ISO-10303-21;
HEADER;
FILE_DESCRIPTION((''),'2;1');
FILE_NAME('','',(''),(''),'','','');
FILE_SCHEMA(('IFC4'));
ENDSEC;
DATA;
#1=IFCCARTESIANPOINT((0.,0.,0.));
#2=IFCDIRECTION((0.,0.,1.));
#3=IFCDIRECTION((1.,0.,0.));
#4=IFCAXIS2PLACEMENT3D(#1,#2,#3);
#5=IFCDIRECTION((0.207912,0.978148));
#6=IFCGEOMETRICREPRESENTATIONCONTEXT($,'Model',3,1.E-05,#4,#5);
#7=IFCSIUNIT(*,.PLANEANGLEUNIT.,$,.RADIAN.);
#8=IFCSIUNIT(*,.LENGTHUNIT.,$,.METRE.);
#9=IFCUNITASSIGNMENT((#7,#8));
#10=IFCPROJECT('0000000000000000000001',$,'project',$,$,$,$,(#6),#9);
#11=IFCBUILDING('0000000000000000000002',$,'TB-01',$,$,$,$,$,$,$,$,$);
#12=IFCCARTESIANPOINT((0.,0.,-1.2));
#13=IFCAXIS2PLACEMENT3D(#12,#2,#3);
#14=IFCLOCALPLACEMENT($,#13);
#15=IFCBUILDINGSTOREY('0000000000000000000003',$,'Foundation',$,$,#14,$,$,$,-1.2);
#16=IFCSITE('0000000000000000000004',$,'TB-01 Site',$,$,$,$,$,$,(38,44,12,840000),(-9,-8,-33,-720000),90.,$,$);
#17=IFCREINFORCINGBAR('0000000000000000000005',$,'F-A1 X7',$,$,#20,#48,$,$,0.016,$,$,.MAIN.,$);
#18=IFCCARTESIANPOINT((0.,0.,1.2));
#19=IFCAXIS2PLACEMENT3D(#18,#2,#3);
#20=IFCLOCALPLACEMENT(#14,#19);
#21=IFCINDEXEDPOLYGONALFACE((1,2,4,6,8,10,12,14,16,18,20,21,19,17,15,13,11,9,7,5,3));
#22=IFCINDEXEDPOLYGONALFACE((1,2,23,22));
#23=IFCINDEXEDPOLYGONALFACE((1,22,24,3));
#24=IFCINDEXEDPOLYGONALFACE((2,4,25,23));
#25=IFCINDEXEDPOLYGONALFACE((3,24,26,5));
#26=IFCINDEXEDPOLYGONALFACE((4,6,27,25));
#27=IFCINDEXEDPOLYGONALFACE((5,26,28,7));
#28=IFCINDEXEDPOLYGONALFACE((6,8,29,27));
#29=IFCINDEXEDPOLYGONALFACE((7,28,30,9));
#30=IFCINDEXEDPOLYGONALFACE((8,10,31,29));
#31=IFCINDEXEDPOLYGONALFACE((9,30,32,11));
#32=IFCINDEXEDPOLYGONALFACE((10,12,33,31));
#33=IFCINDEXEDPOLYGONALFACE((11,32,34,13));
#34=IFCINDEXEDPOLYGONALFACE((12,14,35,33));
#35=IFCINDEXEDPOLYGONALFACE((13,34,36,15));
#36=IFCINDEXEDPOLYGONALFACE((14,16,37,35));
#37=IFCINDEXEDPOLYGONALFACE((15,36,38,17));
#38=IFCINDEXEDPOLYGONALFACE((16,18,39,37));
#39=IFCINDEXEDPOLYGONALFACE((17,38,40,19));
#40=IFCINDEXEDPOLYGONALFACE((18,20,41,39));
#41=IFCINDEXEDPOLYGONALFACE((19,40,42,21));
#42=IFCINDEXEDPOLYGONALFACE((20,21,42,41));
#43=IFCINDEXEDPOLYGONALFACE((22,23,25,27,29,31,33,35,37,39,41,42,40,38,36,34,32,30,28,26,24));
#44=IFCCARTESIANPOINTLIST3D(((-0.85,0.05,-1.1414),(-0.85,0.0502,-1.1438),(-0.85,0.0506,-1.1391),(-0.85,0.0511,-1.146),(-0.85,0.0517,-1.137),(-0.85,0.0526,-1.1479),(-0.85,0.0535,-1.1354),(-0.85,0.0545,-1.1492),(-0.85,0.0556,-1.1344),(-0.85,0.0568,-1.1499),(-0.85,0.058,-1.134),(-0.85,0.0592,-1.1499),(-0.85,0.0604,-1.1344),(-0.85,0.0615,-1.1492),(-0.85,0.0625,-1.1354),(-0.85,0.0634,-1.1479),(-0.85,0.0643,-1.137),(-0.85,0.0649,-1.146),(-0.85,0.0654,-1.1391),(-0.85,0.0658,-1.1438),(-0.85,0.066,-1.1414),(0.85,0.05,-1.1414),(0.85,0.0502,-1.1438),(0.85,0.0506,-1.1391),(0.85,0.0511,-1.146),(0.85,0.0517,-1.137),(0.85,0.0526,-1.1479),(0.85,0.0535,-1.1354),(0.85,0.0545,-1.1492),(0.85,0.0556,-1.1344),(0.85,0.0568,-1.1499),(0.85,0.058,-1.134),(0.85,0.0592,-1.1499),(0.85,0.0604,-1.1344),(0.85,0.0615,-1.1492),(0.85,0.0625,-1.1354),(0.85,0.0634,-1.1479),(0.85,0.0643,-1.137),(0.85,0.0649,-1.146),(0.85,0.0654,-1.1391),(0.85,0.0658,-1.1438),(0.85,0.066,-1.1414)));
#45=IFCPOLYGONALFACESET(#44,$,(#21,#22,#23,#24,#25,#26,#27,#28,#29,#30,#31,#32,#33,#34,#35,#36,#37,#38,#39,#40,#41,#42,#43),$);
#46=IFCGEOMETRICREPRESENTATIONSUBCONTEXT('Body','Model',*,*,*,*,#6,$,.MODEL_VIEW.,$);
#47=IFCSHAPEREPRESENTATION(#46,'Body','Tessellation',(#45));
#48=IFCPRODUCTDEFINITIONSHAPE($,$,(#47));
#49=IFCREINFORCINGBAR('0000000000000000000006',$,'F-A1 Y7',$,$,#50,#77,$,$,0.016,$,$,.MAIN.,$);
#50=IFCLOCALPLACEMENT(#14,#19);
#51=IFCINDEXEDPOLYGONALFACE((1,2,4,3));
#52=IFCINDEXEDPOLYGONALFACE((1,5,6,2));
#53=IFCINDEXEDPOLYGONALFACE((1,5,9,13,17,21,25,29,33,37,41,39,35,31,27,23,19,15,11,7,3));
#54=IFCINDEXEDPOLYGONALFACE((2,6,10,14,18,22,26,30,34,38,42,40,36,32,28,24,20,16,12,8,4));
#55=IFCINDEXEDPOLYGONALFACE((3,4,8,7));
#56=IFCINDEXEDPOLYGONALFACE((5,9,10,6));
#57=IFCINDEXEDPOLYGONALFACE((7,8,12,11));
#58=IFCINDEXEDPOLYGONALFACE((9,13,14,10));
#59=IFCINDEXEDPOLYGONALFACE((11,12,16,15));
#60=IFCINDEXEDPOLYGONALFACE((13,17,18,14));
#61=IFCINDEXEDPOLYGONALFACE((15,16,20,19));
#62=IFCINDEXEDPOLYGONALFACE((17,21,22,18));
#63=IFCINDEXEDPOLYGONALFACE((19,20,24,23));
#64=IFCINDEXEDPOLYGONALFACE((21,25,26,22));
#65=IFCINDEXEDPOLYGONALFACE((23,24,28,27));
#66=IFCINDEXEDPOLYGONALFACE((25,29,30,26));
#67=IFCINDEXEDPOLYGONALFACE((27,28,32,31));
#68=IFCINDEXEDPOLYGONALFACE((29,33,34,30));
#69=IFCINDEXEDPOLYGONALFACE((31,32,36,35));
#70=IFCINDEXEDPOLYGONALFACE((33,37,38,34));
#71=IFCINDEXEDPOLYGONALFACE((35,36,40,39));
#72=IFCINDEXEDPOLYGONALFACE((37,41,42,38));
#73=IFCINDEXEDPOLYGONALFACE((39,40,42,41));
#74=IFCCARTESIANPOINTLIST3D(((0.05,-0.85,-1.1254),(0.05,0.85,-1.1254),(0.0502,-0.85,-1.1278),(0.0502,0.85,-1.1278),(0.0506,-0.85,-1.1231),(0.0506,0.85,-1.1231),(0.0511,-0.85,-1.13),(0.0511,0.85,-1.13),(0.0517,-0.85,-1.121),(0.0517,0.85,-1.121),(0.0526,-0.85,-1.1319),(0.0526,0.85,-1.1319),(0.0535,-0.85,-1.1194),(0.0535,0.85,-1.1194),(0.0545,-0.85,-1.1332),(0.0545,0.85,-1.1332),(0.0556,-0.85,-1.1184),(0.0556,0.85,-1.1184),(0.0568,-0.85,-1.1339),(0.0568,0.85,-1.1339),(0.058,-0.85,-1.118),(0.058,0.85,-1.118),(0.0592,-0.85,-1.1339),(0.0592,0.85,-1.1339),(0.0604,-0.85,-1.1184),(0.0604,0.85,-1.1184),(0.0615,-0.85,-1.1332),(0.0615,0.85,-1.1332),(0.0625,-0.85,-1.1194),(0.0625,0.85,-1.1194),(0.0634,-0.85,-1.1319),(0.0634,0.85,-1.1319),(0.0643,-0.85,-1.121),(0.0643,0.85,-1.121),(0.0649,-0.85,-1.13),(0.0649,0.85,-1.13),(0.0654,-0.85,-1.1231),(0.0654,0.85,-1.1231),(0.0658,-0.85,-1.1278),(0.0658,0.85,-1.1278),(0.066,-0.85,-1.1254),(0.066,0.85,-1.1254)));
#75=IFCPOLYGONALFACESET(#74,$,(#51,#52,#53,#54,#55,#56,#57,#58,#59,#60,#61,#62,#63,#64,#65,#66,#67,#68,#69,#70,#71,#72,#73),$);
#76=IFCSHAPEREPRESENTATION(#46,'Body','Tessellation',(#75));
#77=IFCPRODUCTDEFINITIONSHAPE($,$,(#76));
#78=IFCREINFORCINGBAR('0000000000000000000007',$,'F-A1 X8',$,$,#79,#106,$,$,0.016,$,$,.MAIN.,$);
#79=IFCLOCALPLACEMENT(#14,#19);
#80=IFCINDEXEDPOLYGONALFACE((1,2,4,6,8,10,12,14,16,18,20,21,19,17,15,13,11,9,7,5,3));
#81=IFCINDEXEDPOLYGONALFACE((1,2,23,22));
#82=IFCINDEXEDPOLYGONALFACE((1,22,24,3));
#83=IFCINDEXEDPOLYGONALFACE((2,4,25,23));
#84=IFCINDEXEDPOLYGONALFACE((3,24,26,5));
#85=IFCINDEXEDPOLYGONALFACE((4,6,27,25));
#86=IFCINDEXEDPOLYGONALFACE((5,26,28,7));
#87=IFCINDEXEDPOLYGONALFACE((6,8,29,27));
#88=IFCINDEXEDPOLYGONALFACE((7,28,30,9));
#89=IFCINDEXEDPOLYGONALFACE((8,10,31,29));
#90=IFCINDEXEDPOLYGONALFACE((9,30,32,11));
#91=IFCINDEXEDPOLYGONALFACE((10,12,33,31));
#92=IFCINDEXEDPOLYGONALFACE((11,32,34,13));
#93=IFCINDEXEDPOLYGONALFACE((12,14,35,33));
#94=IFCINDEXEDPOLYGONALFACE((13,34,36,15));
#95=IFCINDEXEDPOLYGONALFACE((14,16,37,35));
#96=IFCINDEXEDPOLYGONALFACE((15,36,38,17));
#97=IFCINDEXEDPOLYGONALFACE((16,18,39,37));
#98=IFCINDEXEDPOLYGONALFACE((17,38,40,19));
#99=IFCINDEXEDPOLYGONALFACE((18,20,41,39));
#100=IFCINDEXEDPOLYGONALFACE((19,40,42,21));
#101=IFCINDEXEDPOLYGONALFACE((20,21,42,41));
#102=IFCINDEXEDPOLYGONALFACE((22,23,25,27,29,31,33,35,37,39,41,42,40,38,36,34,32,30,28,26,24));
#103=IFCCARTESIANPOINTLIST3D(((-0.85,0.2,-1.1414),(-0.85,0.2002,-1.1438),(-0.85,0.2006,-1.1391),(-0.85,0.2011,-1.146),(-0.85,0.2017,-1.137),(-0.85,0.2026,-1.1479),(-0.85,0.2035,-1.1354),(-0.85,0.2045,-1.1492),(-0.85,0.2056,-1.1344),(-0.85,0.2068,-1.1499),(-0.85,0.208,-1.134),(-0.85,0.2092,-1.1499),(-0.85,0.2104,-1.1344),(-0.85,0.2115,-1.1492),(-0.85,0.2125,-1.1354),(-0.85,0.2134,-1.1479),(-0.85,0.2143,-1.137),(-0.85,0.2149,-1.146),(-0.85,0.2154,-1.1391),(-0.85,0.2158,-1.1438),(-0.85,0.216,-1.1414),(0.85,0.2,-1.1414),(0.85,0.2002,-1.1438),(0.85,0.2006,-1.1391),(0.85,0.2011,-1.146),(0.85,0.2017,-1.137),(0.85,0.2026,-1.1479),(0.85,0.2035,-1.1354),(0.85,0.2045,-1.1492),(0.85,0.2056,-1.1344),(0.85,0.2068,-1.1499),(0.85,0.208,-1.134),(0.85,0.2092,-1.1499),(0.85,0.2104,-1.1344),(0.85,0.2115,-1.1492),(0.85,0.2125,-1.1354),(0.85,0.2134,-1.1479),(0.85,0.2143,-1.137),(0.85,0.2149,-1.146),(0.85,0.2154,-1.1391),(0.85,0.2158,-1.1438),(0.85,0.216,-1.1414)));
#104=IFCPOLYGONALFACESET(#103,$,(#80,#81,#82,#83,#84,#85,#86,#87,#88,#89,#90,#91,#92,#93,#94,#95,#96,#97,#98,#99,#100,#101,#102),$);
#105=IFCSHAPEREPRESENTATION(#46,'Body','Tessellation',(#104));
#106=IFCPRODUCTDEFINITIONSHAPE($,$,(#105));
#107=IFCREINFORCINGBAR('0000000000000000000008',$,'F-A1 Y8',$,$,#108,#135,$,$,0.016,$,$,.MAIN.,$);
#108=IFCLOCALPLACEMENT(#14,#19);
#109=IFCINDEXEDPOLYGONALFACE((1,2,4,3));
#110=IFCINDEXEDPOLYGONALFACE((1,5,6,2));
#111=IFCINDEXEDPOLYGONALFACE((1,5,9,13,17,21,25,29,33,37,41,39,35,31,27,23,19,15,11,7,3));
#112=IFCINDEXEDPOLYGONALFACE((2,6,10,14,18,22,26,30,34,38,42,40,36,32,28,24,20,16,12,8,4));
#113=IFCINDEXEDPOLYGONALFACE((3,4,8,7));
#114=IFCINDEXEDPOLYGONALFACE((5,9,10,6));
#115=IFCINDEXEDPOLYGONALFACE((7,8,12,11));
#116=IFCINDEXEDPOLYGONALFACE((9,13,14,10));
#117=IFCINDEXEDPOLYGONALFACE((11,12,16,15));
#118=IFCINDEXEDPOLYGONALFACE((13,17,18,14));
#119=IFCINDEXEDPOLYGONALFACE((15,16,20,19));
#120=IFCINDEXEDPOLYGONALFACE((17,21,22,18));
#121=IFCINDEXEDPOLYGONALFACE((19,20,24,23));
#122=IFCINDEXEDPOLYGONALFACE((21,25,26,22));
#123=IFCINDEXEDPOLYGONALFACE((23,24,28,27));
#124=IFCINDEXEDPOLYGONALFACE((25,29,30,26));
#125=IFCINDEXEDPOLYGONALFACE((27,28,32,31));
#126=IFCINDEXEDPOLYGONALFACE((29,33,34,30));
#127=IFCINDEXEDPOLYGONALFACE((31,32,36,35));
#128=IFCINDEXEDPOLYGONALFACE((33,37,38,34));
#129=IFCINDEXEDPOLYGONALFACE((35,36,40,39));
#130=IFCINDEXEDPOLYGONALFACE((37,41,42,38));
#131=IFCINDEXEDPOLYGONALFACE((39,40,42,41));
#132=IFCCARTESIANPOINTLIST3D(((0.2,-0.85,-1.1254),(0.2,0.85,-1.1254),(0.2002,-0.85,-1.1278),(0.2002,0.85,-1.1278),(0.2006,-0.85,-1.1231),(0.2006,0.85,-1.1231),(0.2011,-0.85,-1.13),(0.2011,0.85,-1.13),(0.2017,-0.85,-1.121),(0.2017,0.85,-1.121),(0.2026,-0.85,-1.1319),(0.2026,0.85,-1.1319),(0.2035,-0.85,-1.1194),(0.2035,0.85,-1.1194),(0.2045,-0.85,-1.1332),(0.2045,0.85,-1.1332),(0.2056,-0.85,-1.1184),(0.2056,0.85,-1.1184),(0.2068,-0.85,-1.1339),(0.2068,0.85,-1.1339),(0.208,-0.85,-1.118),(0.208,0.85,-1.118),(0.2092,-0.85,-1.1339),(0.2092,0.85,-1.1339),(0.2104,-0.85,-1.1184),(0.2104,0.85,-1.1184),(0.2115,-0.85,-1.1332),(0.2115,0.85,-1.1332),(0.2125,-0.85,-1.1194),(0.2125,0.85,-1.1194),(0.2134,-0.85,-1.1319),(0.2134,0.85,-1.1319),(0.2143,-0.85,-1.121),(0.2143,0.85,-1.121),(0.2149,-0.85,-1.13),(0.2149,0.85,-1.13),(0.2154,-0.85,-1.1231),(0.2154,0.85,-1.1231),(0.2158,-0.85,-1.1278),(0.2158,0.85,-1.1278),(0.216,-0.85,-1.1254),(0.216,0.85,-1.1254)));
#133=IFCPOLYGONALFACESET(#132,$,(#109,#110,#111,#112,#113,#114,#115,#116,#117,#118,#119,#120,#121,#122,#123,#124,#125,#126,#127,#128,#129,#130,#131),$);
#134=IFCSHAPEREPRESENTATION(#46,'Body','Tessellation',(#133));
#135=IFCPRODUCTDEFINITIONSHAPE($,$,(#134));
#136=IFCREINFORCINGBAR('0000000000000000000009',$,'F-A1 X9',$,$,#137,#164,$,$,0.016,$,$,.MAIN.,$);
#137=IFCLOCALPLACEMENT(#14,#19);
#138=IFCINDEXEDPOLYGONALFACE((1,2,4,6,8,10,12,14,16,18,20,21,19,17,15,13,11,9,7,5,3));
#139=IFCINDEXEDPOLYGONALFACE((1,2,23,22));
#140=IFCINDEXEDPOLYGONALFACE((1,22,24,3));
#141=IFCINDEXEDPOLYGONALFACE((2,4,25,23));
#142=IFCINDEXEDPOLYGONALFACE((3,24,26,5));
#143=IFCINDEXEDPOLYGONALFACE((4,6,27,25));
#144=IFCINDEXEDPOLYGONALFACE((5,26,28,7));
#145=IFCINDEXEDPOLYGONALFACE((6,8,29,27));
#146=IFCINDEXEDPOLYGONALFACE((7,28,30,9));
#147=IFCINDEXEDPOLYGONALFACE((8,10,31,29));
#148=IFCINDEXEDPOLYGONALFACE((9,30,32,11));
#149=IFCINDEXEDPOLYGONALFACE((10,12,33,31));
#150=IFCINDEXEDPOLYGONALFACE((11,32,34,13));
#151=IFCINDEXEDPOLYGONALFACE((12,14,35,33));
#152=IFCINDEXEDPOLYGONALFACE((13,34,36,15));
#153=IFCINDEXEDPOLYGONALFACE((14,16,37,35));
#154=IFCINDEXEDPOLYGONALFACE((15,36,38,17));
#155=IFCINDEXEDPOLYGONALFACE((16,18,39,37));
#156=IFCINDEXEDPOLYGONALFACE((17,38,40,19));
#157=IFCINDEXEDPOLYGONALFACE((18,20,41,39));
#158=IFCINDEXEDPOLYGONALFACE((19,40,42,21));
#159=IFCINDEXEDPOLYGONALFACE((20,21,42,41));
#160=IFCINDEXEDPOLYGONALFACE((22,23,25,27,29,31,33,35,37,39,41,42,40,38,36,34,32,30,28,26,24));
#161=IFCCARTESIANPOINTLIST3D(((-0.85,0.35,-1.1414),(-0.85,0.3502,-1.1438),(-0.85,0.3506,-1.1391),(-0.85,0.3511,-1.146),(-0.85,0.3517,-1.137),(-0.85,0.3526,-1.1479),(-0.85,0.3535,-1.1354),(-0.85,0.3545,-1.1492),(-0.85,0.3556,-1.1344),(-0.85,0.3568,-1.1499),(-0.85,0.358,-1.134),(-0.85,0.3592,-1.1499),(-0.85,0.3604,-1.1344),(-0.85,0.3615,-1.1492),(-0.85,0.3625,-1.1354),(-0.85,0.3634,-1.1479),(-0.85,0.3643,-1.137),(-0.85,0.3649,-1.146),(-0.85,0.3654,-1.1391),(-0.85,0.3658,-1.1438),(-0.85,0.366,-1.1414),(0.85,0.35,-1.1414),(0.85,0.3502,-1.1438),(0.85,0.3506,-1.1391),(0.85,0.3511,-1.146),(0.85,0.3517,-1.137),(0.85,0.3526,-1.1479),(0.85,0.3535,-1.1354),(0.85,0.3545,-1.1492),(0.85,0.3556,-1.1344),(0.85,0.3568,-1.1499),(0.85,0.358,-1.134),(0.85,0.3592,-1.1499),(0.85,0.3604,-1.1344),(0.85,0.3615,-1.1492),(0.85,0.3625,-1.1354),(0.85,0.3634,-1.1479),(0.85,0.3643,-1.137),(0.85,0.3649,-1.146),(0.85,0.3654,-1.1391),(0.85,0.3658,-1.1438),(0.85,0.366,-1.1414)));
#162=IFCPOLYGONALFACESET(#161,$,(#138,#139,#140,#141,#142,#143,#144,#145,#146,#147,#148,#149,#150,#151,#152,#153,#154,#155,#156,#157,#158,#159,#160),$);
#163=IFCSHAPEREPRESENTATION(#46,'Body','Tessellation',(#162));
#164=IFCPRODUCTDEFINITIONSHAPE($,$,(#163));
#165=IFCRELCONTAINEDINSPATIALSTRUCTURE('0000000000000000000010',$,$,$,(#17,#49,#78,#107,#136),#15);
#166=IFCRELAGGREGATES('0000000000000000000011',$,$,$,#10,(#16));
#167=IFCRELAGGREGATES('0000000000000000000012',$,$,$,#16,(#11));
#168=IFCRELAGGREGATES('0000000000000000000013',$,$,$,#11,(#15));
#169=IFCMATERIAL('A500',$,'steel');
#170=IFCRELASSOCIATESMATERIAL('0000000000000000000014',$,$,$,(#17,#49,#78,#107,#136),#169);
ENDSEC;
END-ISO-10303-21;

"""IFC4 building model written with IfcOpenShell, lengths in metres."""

from ifc_helpers import new_model, entity, si_unit, direction, frame, origin_with_axes, place, context, subcontext, project, spatial, material, element, save


model = new_model("IFC4")

# Units and contexts
model_context = context("Model", 3, precision=1e-05, world=origin_with_axes(), true_north=direction((0.207912, 0.978148)))
body_context = subcontext(model_context, "Body", "Model", "MODEL_VIEW")
ifc_project = project(units=[si_unit("PLANEANGLEUNIT", "RADIAN"), si_unit("LENGTHUNIT", "METRE")], contexts=[model_context])

# Site, building, storey
site = spatial("IfcSite", under=ifc_project, Name="TB-01 Site", RefLatitude=(38, 44, 12, 840000), RefLongitude=(-9, -8, -33, -720000), RefElevation=90.0)
building = spatial("IfcBuilding", under=site, Name="TB-01")
storey_placement = place(None, frame((0.0, 0.0, -1.2), z_axis=(0.0, 0.0, 1.0), x_axis=(1.0, 0.0, 0.0)))
storey = spatial("IfcBuildingStorey", under=building, at=storey_placement, Name="Foundation", Elevation=-1.2)

# Reinforcing bars
ifc_material_1 = material(Name="A500", Category="steel")
reinforcing_bar_1_placement = place(storey_placement, frame((0.0, 0.0, 1.2), z_axis=(0.0, 0.0, 1.0), x_axis=(1.0, 0.0, 0.0)))
element("IfcReinforcingBar", 1, at=reinforcing_bar_1_placement, inside=storey, material=ifc_material_1, Name="F-A1 X7", NominalDiameter=0.016, PredefinedType="MAIN", context=body_context, shape_type="AdvancedSweptSolid", body=[
    entity("IfcSweptDiskSolid", entity("IfcPolyline", [entity("IfcCartesianPoint", [-0.85, 0.058, -1.142]), entity("IfcCartesianPoint", [0.85, 0.058, -1.142])]), 0.008),
])
reinforcing_bar_2_placement = place(storey_placement, frame((0.0, 0.0, 1.2), z_axis=(0.0, 0.0, 1.0), x_axis=(1.0, 0.0, 0.0)))
element("IfcReinforcingBar", 2, at=reinforcing_bar_2_placement, inside=storey, material=ifc_material_1, Name="F-A1 Y7", NominalDiameter=0.016, PredefinedType="MAIN", context=body_context, shape_type="AdvancedSweptSolid", body=[
    entity("IfcSweptDiskSolid", entity("IfcPolyline", [entity("IfcCartesianPoint", [0.058, -0.85, -1.126]), entity("IfcCartesianPoint", [0.058, 0.85, -1.126])]), 0.008),
])
reinforcing_bar_3_placement = place(storey_placement, frame((0.0, 0.0, 1.2), z_axis=(0.0, 0.0, 1.0), x_axis=(1.0, 0.0, 0.0)))
element("IfcReinforcingBar", 3, at=reinforcing_bar_3_placement, inside=storey, material=ifc_material_1, Name="F-A1 X8", NominalDiameter=0.016, PredefinedType="MAIN", context=body_context, shape_type="AdvancedSweptSolid", body=[
    entity("IfcSweptDiskSolid", entity("IfcPolyline", [entity("IfcCartesianPoint", [-0.85, 0.208, -1.142]), entity("IfcCartesianPoint", [0.85, 0.208, -1.142])]), 0.008),
])
reinforcing_bar_4_placement = place(storey_placement, frame((0.0, 0.0, 1.2), z_axis=(0.0, 0.0, 1.0), x_axis=(1.0, 0.0, 0.0)))
element("IfcReinforcingBar", 4, at=reinforcing_bar_4_placement, inside=storey, material=ifc_material_1, Name="F-A1 Y8", NominalDiameter=0.016, PredefinedType="MAIN", context=body_context, shape_type="AdvancedSweptSolid", body=[
    entity("IfcSweptDiskSolid", entity("IfcPolyline", [entity("IfcCartesianPoint", [0.208, -0.85, -1.126]), entity("IfcCartesianPoint", [0.208, 0.85, -1.126])]), 0.008),
])
reinforcing_bar_5_placement = place(storey_placement, frame((0.0, 0.0, 1.2), z_axis=(0.0, 0.0, 1.0), x_axis=(1.0, 0.0, 0.0)))
element("IfcReinforcingBar", 5, at=reinforcing_bar_5_placement, inside=storey, material=ifc_material_1, Name="F-A1 X9", NominalDiameter=0.016, PredefinedType="MAIN", context=body_context, shape_type="AdvancedSweptSolid", body=[
    entity("IfcSweptDiskSolid", entity("IfcPolyline", [entity("IfcCartesianPoint", [-0.85, 0.358, -1.142]), entity("IfcCartesianPoint", [0.85, 0.358, -1.142])]), 0.008),
])

save(model, "model.ifc")
